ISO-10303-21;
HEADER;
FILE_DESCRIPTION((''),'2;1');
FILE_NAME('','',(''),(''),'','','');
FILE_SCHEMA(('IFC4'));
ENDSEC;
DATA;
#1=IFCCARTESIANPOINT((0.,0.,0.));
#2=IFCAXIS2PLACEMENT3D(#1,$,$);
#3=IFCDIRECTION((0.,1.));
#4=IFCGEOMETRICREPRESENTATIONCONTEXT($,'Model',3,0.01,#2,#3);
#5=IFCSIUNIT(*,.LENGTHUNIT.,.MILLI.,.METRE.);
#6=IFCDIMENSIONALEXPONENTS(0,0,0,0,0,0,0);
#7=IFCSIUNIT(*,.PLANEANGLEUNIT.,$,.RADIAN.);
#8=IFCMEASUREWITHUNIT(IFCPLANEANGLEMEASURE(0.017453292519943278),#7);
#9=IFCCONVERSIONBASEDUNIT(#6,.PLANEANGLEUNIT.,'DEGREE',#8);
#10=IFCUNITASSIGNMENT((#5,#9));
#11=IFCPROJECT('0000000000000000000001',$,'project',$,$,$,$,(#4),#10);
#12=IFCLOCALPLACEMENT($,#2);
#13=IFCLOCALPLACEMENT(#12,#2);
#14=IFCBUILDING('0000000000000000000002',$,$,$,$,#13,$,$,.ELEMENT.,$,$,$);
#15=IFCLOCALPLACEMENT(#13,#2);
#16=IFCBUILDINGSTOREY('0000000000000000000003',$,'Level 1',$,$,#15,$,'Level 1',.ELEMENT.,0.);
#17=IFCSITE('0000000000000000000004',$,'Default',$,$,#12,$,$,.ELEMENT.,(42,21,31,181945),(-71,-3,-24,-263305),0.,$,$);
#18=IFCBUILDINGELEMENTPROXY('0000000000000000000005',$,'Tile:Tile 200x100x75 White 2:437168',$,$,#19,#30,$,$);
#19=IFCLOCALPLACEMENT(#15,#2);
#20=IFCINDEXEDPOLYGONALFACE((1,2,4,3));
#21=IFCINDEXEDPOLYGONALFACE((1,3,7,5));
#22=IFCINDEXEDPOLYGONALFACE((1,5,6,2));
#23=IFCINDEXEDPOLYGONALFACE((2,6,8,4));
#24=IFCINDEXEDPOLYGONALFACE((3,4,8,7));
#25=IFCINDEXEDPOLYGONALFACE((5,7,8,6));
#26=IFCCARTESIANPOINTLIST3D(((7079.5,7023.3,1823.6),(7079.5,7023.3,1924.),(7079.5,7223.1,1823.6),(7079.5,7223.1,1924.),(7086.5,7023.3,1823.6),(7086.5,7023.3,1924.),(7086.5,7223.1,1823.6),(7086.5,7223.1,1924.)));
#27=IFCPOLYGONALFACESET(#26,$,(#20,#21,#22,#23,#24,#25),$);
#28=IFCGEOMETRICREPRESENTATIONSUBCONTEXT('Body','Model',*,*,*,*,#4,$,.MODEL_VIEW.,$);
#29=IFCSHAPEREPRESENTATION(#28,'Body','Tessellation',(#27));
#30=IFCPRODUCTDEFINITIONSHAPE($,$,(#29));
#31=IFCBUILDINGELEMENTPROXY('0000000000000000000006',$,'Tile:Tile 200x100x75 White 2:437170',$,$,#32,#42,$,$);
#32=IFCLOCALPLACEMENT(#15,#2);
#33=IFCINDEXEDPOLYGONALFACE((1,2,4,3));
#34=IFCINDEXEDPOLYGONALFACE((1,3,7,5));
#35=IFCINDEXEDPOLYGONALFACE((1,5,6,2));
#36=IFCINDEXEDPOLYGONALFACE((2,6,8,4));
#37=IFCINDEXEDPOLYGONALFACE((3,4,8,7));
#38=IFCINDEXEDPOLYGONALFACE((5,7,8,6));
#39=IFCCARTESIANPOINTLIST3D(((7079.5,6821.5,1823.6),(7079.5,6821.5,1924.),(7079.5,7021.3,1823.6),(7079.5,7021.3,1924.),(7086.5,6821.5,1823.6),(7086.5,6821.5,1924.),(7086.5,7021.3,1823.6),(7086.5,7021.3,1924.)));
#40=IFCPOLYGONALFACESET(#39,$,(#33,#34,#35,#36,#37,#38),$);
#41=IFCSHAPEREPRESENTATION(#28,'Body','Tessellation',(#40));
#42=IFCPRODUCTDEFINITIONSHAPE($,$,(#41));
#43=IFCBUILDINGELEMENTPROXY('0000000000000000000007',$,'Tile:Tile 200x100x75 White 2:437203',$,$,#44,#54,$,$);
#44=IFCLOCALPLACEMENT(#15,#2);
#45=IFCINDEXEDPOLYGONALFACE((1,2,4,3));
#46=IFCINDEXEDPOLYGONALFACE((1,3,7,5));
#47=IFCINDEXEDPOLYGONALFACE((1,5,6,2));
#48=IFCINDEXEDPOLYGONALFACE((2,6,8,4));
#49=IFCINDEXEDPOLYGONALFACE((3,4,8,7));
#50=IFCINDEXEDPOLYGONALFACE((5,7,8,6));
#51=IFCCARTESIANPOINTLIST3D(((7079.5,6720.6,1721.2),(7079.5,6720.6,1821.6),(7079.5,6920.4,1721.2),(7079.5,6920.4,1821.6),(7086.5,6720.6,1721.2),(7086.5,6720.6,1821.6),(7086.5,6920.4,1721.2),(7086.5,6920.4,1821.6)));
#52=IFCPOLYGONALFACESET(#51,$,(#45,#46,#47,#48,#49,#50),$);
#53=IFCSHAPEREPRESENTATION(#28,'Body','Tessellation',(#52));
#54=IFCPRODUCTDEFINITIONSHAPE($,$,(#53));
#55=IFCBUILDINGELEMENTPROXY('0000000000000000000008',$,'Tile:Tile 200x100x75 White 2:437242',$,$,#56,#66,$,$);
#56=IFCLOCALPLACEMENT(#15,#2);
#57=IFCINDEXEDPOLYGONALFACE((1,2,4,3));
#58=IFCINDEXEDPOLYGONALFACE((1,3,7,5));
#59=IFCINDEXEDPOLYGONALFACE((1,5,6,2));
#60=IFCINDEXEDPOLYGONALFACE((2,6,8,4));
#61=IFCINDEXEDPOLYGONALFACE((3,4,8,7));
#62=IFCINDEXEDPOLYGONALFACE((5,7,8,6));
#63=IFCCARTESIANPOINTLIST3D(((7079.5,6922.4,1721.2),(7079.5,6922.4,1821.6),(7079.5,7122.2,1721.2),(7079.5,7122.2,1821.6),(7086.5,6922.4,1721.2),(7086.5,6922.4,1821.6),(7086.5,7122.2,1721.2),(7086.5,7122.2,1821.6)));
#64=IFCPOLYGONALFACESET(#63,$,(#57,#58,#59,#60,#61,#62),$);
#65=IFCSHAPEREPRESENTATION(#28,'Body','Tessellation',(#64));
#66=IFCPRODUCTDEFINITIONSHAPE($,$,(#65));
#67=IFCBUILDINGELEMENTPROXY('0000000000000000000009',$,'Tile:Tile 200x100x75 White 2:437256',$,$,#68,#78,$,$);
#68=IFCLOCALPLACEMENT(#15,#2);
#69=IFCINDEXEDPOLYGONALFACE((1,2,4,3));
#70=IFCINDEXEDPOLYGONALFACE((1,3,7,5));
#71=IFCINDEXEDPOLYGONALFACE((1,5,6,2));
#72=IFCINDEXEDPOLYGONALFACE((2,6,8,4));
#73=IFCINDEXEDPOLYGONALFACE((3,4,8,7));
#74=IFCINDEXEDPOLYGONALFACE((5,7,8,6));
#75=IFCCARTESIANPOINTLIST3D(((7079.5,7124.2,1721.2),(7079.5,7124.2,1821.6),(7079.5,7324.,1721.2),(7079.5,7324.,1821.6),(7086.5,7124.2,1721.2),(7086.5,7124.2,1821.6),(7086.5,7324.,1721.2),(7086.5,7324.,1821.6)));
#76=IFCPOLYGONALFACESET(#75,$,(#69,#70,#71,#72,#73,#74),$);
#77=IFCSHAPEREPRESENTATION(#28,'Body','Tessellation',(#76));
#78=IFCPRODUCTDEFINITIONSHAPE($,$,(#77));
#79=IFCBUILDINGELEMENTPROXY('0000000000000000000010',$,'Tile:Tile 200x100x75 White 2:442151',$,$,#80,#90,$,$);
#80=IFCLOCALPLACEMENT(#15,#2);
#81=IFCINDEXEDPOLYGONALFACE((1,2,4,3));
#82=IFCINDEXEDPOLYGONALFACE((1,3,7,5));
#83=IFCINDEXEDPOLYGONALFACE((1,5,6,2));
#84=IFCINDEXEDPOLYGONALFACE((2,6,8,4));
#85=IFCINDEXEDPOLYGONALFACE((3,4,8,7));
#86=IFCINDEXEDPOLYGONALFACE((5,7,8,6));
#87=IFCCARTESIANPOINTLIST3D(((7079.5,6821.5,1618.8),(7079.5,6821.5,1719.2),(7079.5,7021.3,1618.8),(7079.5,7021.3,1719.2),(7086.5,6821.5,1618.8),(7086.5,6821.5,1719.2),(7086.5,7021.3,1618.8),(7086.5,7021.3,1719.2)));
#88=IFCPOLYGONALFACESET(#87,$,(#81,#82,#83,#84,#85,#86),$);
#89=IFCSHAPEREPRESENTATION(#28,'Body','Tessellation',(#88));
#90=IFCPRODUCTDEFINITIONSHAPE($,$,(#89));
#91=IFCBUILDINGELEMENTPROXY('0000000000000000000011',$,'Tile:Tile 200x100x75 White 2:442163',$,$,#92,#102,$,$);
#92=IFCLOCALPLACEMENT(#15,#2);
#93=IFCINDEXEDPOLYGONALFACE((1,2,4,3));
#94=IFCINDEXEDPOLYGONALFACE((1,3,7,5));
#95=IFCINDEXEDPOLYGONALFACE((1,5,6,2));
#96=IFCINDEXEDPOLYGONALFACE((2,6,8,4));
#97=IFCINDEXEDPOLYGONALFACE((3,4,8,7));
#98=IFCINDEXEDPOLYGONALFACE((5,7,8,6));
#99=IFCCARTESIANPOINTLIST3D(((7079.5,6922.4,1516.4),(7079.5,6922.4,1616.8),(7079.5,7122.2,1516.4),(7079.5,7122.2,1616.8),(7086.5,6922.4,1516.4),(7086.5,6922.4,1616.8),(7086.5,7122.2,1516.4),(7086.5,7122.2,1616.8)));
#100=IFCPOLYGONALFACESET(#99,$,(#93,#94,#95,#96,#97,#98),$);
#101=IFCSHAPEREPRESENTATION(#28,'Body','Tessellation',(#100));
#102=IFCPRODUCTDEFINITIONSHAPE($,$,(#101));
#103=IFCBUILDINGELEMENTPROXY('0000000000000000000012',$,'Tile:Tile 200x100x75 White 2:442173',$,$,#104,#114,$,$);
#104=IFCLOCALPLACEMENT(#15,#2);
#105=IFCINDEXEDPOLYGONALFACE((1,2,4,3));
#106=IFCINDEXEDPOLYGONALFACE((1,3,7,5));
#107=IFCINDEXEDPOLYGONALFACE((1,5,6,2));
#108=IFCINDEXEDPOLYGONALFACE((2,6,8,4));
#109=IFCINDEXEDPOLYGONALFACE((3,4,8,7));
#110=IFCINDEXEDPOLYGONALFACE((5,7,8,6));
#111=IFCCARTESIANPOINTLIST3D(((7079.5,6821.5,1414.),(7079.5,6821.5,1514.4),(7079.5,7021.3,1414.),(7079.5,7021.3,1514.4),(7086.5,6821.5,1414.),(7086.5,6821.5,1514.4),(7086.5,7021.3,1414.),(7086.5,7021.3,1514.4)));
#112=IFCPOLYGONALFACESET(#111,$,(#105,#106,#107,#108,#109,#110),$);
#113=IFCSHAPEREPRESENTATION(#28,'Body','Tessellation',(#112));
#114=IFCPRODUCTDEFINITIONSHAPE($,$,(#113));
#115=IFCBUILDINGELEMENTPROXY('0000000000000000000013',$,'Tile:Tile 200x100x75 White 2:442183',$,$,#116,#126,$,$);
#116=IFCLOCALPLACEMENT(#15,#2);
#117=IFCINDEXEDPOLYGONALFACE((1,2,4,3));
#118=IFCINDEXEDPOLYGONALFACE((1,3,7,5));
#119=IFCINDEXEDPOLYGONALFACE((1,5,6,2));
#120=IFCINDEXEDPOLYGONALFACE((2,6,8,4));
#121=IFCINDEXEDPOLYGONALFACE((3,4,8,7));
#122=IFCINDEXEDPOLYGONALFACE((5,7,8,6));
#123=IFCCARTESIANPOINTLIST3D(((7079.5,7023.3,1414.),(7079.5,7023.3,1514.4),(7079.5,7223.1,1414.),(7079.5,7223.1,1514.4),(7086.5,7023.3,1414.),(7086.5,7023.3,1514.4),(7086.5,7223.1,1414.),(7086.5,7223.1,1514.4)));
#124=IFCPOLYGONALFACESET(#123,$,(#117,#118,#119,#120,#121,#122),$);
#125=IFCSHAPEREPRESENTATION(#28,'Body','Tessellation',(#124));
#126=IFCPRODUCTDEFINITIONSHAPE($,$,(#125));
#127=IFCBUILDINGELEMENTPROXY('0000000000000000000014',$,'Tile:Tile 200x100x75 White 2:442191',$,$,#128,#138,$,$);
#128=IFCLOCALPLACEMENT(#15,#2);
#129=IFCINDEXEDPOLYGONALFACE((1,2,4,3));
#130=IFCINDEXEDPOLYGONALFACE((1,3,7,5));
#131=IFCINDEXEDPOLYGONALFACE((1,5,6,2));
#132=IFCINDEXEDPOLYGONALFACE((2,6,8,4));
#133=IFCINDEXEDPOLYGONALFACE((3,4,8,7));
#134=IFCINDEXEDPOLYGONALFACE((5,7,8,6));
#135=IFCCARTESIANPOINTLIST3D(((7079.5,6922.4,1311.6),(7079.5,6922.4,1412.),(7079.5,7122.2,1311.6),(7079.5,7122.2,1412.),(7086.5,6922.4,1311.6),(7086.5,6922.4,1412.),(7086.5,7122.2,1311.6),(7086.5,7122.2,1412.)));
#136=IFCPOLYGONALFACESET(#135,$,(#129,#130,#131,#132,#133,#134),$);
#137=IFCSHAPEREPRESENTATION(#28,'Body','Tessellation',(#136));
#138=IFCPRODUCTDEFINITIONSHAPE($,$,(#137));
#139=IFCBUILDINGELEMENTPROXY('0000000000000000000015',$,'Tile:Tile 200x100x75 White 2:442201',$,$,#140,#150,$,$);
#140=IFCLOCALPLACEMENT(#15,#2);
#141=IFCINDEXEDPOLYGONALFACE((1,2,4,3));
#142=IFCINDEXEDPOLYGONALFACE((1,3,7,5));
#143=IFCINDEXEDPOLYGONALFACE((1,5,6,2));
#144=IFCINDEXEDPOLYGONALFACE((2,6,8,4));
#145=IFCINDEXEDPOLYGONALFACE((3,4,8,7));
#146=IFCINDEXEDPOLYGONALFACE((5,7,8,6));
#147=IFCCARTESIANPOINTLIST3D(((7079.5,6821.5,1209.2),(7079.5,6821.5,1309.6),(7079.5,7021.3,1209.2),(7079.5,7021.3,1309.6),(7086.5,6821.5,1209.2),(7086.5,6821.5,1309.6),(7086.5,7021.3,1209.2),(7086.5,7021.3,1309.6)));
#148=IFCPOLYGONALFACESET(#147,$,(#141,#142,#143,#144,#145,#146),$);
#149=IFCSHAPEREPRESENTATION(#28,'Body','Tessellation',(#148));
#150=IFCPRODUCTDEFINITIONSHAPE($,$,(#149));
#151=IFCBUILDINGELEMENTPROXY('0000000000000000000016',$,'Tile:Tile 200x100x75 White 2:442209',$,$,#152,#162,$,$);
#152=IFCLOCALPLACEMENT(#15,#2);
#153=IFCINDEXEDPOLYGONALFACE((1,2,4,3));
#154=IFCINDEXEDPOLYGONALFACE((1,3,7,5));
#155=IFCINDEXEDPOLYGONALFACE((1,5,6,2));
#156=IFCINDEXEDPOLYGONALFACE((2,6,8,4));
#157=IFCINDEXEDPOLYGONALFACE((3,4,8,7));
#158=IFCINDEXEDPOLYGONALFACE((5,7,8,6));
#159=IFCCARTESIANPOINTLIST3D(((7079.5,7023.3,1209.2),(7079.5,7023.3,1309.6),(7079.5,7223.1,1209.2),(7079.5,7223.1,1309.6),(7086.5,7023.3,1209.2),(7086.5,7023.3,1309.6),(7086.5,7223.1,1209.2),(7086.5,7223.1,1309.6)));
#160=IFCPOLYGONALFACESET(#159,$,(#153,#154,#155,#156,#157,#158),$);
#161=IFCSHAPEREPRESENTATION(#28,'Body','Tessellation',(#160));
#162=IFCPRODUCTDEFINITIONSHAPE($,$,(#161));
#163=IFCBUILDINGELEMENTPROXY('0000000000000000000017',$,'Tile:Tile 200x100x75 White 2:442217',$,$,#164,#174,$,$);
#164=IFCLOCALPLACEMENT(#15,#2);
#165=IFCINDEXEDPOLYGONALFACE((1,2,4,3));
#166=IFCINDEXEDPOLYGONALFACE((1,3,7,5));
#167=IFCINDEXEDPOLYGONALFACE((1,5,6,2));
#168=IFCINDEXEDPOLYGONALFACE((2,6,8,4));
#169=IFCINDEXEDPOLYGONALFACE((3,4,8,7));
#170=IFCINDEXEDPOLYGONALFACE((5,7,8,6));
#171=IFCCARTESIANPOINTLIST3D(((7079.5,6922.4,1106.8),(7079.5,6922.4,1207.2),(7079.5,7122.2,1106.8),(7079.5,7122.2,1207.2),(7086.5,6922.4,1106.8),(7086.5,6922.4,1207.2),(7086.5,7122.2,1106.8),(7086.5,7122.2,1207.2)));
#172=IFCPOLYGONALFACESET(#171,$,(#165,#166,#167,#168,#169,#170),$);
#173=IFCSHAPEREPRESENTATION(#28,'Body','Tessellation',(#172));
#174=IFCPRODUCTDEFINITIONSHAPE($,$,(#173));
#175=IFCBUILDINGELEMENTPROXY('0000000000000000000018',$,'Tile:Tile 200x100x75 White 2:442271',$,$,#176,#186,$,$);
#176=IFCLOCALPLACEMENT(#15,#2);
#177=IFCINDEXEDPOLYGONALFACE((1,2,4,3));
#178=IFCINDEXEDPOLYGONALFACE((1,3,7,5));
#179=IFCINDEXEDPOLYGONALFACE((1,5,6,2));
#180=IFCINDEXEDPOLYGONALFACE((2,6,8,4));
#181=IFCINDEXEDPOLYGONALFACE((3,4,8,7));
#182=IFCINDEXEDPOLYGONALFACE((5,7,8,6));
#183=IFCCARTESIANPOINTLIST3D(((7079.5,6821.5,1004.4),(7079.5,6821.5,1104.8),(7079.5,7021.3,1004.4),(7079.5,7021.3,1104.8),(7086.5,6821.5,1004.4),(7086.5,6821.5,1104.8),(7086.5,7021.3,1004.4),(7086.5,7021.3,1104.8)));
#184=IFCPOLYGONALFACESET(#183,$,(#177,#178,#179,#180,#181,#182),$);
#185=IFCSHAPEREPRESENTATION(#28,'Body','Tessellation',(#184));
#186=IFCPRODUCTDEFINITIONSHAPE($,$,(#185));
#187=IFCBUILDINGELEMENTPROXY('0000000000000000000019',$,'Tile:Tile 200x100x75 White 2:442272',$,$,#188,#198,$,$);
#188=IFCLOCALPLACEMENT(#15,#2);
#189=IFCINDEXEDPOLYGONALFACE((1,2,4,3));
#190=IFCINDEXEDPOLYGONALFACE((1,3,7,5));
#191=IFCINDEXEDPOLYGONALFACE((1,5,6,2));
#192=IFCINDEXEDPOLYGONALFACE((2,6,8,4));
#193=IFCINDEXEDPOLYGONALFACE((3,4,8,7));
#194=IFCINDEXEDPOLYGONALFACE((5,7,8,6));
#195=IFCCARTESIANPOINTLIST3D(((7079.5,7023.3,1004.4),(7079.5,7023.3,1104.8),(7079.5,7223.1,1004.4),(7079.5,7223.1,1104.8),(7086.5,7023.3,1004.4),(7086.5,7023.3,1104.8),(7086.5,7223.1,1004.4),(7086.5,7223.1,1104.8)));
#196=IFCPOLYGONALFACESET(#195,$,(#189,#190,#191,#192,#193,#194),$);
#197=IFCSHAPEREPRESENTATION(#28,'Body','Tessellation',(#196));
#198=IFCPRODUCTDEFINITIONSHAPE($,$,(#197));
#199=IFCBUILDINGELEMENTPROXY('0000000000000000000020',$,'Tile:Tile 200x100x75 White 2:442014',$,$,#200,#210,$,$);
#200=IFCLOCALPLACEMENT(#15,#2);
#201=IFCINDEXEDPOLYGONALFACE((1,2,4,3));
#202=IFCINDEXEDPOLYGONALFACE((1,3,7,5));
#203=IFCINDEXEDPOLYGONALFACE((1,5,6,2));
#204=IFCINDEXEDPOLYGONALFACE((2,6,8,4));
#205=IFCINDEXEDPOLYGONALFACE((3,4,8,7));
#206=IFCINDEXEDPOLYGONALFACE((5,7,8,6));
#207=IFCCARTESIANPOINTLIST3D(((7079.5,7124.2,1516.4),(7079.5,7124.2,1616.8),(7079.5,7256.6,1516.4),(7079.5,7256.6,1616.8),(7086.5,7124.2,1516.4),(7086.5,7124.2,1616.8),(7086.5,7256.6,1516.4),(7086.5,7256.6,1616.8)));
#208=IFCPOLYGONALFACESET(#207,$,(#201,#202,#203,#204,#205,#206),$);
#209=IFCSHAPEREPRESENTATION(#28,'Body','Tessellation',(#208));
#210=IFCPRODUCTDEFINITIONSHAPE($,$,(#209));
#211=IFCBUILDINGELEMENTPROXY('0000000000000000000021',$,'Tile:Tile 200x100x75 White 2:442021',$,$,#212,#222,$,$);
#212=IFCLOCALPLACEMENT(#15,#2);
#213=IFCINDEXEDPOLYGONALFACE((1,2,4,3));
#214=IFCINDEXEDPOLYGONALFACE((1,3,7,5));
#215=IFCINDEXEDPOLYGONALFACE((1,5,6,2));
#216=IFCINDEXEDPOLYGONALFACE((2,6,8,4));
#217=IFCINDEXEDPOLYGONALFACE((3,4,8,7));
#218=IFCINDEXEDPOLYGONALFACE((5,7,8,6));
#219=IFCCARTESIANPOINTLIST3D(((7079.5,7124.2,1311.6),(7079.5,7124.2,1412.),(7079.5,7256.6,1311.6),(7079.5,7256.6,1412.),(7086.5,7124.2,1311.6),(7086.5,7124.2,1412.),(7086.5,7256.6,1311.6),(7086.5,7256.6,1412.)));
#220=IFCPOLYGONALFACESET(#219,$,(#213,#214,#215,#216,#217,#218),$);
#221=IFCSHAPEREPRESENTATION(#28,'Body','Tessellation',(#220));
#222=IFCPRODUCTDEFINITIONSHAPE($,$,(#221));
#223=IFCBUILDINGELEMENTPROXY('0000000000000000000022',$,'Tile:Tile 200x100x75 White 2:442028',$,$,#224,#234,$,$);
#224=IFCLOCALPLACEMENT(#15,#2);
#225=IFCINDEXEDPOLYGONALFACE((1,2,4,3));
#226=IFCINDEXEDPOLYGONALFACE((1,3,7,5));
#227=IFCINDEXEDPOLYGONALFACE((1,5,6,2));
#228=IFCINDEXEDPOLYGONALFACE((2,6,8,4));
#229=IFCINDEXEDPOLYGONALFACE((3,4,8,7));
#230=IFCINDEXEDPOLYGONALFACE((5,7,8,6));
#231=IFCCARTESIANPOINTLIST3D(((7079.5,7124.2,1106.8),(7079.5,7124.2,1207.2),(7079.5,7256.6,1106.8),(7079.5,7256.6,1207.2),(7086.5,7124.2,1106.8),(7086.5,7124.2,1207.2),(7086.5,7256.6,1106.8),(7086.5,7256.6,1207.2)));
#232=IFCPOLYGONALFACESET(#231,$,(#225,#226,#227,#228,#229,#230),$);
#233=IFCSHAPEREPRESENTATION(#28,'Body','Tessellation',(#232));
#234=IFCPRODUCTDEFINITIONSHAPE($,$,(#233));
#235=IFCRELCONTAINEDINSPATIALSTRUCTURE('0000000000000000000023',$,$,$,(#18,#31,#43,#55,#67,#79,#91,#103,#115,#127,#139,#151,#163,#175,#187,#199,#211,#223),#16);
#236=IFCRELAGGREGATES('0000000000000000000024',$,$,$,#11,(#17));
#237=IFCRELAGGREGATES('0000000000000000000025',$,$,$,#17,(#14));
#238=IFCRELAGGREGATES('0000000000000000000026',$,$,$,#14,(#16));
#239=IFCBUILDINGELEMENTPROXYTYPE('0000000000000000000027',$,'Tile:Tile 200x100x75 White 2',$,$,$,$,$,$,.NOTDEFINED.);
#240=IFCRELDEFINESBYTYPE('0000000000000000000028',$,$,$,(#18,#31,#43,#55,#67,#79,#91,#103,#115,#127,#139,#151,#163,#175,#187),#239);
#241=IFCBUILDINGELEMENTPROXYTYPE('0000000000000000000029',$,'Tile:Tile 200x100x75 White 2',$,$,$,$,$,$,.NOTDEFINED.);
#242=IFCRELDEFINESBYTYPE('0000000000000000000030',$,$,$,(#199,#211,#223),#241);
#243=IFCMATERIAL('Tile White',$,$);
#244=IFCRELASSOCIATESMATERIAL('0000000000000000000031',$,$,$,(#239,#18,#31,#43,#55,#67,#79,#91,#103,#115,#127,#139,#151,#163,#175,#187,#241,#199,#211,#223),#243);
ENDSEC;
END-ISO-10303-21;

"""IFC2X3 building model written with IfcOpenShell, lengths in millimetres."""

from ifc_helpers import new_model, entity, si_unit, converted_unit, direction, frame, frame_2d, origin, place, context, subcontext, project, spatial, rectangle, extrude, source, transform, mapped, material, type_object, type_shapes, element, save


model = new_model("IFC2X3")

# Units and contexts
model_context = context("Model", 3, precision=0.01, world=origin(), true_north=direction((0.0, 1.0)))
body_context = subcontext(model_context, "Body", "Model", "MODEL_VIEW")
ifc_project = project(units=[si_unit("LENGTHUNIT", "METRE", prefix="MILLI"), converted_unit("PLANEANGLEUNIT", "DEGREE", entity("IfcPlaneAngleMeasure", 0.017453292519943278), si_unit("PLANEANGLEUNIT", "RADIAN"), dimensions=[0, 0, 0, 0, 0, 0, 0])], contexts=[model_context])

# Site, building, storey
site_placement = place(None, origin())
site = spatial("IfcSite", under=ifc_project, at=site_placement, Name="Default", CompositionType="ELEMENT", RefLatitude=(42, 21, 31, 181945), RefLongitude=(-71, -3, -24, -263305), RefElevation=0.0)
building_placement = place(site_placement, origin())
building = spatial("IfcBuilding", under=site, at=building_placement, CompositionType="ELEMENT")
storey_placement = place(building_placement, origin())
storey = spatial("IfcBuildingStorey", under=building, at=storey_placement, Name="Level 1", LongName="Level 1", CompositionType="ELEMENT", Elevation=0.0)

# Building element proxies
ifc_material_1 = material(Name="Tile White")
building_element_proxy_type_1 = type_object("IfcBuildingElementProxyType", Name="Tile:Tile 200x100x75 White 2", PredefinedType="NOTDEFINED", material=ifc_material_1)
shared_shape_1 = source(origin(), body_context, "Body", "SweptSolid", [
    extrude(rectangle(XDim=199.8, YDim=100.4, at=frame_2d((0.0, 0.0), x_axis=(1.0, 0.0))), frame((-50.2, -99.9, 0.0), z_axis=(0.0, 0.0, 1.0), x_axis=(0.0, -1.0, 0.0)), (0.0, 0.0, 1.0), 7.0),
])
type_shapes(building_element_proxy_type_1, [shared_shape_1])
for number, where, z_axis, x_axis, name in (
    (1, (7086.5, 7223.1, 1924.0), (-1.0, 0.0, 0.0), (0.0, 0.0, 1.0), "Tile:Tile 200x100x75 White 2:437168"),
    (2, (7086.5, 7021.3, 1924.0), (-1.0, 0.0, 0.0), (0.0, 0.0, 1.0), "Tile:Tile 200x100x75 White 2:437170"),
    (3, (7086.5, 6920.4, 1821.6), (-1.0, 0.0, 0.0), (0.0, 0.0, 1.0), "Tile:Tile 200x100x75 White 2:437203"),
    (4, (7086.5, 7122.2, 1821.6), (-1.0, 0.0, 0.0), (0.0, 0.0, 1.0), "Tile:Tile 200x100x75 White 2:437242"),
    (5, (7086.5, 7324.0, 1821.6), (-1.0, 0.0, 0.0), (0.0, 0.0, 1.0), "Tile:Tile 200x100x75 White 2:437256"),
    (6, (7086.5, 7021.3, 1719.2), (-1.0, 0.0, 0.0), (0.0, 0.0, 1.0), "Tile:Tile 200x100x75 White 2:442151"),
    (7, (7086.5, 7122.2, 1616.8), (-1.0, 0.0, 0.0), (0.0, 0.0, 1.0), "Tile:Tile 200x100x75 White 2:442163"),
    (8, (7086.5, 7021.3, 1514.4), (-1.0, 0.0, 0.0), (0.0, 0.0, 1.0), "Tile:Tile 200x100x75 White 2:442173"),
    (9, (7086.5, 7223.1, 1514.4), (-1.0, 0.0, 0.0), (0.0, 0.0, 1.0), "Tile:Tile 200x100x75 White 2:442183"),
    (10, (7086.5, 7122.2, 1412.0), (-1.0, 0.0, 0.0), (0.0, 0.0, 1.0), "Tile:Tile 200x100x75 White 2:442191"),
    (11, (7086.5, 7021.3, 1309.6), (-1.0, 0.0, 0.0), (0.0, 0.0, 1.0), "Tile:Tile 200x100x75 White 2:442201"),
    (12, (7086.5, 7223.1, 1309.6), (-1.0, 0.0, 0.0), (0.0, 0.0, 1.0), "Tile:Tile 200x100x75 White 2:442209"),
    (13, (7086.5, 7122.2, 1207.2), (-1.0, 0.0, 0.0), (0.0, 0.0, 1.0), "Tile:Tile 200x100x75 White 2:442217"),
    (14, (7086.5, 7021.3, 1104.8), (-1.0, 0.0, 0.0), (0.0, 0.0, 1.0), "Tile:Tile 200x100x75 White 2:442271"),
    (15, (7086.5, 7223.1, 1104.8), (-1.0, 0.0, 0.0), (0.0, 0.0, 1.0), "Tile:Tile 200x100x75 White 2:442272"),
):
    element("IfcBuildingElementProxy", number, at=place(storey_placement, frame(where, z_axis=z_axis, x_axis=x_axis)), inside=storey, type_object=building_element_proxy_type_1, material=ifc_material_1, Name=name, context=body_context, shape_type="MappedRepresentation", body=[
        mapped(shared_shape_1, transform((0.0, 0.0, 0.0), scale=1.0)),
    ])
building_element_proxy_type_2 = type_object("IfcBuildingElementProxyType", Name="Tile:Tile 200x100x75 White 2", PredefinedType="NOTDEFINED", material=ifc_material_1)
shared_shape_2 = source(origin(), body_context, "Body", "SweptSolid", [
    extrude(rectangle(XDim=100.4, YDim=132.4, at=frame_2d((0.0, 0.0), x_axis=(1.0, 0.0))), frame((-50.2, 66.2, 0.0)), (0.0, 0.0, 1.0), 7.0),
])
type_shapes(building_element_proxy_type_2, [shared_shape_2])
for number, where, z_axis, x_axis, name in (
    (16, (7086.5, 7124.2, 1616.8), (-1.0, 0.0, 0.0), (0.0, 0.0, 1.0), "Tile:Tile 200x100x75 White 2:442014"),
    (17, (7086.5, 7124.2, 1412.0), (-1.0, 0.0, 0.0), (0.0, 0.0, 1.0), "Tile:Tile 200x100x75 White 2:442021"),
    (18, (7086.5, 7124.2, 1207.2), (-1.0, 0.0, 0.0), (0.0, 0.0, 1.0), "Tile:Tile 200x100x75 White 2:442028"),
):
    element("IfcBuildingElementProxy", number, at=place(storey_placement, frame(where, z_axis=z_axis, x_axis=x_axis)), inside=storey, type_object=building_element_proxy_type_2, material=ifc_material_1, Name=name, context=body_context, shape_type="MappedRepresentation", body=[
        mapped(shared_shape_2, transform((0.0, 0.0, 0.0), scale=1.0)),
    ])

save(model, "model.ifc")
